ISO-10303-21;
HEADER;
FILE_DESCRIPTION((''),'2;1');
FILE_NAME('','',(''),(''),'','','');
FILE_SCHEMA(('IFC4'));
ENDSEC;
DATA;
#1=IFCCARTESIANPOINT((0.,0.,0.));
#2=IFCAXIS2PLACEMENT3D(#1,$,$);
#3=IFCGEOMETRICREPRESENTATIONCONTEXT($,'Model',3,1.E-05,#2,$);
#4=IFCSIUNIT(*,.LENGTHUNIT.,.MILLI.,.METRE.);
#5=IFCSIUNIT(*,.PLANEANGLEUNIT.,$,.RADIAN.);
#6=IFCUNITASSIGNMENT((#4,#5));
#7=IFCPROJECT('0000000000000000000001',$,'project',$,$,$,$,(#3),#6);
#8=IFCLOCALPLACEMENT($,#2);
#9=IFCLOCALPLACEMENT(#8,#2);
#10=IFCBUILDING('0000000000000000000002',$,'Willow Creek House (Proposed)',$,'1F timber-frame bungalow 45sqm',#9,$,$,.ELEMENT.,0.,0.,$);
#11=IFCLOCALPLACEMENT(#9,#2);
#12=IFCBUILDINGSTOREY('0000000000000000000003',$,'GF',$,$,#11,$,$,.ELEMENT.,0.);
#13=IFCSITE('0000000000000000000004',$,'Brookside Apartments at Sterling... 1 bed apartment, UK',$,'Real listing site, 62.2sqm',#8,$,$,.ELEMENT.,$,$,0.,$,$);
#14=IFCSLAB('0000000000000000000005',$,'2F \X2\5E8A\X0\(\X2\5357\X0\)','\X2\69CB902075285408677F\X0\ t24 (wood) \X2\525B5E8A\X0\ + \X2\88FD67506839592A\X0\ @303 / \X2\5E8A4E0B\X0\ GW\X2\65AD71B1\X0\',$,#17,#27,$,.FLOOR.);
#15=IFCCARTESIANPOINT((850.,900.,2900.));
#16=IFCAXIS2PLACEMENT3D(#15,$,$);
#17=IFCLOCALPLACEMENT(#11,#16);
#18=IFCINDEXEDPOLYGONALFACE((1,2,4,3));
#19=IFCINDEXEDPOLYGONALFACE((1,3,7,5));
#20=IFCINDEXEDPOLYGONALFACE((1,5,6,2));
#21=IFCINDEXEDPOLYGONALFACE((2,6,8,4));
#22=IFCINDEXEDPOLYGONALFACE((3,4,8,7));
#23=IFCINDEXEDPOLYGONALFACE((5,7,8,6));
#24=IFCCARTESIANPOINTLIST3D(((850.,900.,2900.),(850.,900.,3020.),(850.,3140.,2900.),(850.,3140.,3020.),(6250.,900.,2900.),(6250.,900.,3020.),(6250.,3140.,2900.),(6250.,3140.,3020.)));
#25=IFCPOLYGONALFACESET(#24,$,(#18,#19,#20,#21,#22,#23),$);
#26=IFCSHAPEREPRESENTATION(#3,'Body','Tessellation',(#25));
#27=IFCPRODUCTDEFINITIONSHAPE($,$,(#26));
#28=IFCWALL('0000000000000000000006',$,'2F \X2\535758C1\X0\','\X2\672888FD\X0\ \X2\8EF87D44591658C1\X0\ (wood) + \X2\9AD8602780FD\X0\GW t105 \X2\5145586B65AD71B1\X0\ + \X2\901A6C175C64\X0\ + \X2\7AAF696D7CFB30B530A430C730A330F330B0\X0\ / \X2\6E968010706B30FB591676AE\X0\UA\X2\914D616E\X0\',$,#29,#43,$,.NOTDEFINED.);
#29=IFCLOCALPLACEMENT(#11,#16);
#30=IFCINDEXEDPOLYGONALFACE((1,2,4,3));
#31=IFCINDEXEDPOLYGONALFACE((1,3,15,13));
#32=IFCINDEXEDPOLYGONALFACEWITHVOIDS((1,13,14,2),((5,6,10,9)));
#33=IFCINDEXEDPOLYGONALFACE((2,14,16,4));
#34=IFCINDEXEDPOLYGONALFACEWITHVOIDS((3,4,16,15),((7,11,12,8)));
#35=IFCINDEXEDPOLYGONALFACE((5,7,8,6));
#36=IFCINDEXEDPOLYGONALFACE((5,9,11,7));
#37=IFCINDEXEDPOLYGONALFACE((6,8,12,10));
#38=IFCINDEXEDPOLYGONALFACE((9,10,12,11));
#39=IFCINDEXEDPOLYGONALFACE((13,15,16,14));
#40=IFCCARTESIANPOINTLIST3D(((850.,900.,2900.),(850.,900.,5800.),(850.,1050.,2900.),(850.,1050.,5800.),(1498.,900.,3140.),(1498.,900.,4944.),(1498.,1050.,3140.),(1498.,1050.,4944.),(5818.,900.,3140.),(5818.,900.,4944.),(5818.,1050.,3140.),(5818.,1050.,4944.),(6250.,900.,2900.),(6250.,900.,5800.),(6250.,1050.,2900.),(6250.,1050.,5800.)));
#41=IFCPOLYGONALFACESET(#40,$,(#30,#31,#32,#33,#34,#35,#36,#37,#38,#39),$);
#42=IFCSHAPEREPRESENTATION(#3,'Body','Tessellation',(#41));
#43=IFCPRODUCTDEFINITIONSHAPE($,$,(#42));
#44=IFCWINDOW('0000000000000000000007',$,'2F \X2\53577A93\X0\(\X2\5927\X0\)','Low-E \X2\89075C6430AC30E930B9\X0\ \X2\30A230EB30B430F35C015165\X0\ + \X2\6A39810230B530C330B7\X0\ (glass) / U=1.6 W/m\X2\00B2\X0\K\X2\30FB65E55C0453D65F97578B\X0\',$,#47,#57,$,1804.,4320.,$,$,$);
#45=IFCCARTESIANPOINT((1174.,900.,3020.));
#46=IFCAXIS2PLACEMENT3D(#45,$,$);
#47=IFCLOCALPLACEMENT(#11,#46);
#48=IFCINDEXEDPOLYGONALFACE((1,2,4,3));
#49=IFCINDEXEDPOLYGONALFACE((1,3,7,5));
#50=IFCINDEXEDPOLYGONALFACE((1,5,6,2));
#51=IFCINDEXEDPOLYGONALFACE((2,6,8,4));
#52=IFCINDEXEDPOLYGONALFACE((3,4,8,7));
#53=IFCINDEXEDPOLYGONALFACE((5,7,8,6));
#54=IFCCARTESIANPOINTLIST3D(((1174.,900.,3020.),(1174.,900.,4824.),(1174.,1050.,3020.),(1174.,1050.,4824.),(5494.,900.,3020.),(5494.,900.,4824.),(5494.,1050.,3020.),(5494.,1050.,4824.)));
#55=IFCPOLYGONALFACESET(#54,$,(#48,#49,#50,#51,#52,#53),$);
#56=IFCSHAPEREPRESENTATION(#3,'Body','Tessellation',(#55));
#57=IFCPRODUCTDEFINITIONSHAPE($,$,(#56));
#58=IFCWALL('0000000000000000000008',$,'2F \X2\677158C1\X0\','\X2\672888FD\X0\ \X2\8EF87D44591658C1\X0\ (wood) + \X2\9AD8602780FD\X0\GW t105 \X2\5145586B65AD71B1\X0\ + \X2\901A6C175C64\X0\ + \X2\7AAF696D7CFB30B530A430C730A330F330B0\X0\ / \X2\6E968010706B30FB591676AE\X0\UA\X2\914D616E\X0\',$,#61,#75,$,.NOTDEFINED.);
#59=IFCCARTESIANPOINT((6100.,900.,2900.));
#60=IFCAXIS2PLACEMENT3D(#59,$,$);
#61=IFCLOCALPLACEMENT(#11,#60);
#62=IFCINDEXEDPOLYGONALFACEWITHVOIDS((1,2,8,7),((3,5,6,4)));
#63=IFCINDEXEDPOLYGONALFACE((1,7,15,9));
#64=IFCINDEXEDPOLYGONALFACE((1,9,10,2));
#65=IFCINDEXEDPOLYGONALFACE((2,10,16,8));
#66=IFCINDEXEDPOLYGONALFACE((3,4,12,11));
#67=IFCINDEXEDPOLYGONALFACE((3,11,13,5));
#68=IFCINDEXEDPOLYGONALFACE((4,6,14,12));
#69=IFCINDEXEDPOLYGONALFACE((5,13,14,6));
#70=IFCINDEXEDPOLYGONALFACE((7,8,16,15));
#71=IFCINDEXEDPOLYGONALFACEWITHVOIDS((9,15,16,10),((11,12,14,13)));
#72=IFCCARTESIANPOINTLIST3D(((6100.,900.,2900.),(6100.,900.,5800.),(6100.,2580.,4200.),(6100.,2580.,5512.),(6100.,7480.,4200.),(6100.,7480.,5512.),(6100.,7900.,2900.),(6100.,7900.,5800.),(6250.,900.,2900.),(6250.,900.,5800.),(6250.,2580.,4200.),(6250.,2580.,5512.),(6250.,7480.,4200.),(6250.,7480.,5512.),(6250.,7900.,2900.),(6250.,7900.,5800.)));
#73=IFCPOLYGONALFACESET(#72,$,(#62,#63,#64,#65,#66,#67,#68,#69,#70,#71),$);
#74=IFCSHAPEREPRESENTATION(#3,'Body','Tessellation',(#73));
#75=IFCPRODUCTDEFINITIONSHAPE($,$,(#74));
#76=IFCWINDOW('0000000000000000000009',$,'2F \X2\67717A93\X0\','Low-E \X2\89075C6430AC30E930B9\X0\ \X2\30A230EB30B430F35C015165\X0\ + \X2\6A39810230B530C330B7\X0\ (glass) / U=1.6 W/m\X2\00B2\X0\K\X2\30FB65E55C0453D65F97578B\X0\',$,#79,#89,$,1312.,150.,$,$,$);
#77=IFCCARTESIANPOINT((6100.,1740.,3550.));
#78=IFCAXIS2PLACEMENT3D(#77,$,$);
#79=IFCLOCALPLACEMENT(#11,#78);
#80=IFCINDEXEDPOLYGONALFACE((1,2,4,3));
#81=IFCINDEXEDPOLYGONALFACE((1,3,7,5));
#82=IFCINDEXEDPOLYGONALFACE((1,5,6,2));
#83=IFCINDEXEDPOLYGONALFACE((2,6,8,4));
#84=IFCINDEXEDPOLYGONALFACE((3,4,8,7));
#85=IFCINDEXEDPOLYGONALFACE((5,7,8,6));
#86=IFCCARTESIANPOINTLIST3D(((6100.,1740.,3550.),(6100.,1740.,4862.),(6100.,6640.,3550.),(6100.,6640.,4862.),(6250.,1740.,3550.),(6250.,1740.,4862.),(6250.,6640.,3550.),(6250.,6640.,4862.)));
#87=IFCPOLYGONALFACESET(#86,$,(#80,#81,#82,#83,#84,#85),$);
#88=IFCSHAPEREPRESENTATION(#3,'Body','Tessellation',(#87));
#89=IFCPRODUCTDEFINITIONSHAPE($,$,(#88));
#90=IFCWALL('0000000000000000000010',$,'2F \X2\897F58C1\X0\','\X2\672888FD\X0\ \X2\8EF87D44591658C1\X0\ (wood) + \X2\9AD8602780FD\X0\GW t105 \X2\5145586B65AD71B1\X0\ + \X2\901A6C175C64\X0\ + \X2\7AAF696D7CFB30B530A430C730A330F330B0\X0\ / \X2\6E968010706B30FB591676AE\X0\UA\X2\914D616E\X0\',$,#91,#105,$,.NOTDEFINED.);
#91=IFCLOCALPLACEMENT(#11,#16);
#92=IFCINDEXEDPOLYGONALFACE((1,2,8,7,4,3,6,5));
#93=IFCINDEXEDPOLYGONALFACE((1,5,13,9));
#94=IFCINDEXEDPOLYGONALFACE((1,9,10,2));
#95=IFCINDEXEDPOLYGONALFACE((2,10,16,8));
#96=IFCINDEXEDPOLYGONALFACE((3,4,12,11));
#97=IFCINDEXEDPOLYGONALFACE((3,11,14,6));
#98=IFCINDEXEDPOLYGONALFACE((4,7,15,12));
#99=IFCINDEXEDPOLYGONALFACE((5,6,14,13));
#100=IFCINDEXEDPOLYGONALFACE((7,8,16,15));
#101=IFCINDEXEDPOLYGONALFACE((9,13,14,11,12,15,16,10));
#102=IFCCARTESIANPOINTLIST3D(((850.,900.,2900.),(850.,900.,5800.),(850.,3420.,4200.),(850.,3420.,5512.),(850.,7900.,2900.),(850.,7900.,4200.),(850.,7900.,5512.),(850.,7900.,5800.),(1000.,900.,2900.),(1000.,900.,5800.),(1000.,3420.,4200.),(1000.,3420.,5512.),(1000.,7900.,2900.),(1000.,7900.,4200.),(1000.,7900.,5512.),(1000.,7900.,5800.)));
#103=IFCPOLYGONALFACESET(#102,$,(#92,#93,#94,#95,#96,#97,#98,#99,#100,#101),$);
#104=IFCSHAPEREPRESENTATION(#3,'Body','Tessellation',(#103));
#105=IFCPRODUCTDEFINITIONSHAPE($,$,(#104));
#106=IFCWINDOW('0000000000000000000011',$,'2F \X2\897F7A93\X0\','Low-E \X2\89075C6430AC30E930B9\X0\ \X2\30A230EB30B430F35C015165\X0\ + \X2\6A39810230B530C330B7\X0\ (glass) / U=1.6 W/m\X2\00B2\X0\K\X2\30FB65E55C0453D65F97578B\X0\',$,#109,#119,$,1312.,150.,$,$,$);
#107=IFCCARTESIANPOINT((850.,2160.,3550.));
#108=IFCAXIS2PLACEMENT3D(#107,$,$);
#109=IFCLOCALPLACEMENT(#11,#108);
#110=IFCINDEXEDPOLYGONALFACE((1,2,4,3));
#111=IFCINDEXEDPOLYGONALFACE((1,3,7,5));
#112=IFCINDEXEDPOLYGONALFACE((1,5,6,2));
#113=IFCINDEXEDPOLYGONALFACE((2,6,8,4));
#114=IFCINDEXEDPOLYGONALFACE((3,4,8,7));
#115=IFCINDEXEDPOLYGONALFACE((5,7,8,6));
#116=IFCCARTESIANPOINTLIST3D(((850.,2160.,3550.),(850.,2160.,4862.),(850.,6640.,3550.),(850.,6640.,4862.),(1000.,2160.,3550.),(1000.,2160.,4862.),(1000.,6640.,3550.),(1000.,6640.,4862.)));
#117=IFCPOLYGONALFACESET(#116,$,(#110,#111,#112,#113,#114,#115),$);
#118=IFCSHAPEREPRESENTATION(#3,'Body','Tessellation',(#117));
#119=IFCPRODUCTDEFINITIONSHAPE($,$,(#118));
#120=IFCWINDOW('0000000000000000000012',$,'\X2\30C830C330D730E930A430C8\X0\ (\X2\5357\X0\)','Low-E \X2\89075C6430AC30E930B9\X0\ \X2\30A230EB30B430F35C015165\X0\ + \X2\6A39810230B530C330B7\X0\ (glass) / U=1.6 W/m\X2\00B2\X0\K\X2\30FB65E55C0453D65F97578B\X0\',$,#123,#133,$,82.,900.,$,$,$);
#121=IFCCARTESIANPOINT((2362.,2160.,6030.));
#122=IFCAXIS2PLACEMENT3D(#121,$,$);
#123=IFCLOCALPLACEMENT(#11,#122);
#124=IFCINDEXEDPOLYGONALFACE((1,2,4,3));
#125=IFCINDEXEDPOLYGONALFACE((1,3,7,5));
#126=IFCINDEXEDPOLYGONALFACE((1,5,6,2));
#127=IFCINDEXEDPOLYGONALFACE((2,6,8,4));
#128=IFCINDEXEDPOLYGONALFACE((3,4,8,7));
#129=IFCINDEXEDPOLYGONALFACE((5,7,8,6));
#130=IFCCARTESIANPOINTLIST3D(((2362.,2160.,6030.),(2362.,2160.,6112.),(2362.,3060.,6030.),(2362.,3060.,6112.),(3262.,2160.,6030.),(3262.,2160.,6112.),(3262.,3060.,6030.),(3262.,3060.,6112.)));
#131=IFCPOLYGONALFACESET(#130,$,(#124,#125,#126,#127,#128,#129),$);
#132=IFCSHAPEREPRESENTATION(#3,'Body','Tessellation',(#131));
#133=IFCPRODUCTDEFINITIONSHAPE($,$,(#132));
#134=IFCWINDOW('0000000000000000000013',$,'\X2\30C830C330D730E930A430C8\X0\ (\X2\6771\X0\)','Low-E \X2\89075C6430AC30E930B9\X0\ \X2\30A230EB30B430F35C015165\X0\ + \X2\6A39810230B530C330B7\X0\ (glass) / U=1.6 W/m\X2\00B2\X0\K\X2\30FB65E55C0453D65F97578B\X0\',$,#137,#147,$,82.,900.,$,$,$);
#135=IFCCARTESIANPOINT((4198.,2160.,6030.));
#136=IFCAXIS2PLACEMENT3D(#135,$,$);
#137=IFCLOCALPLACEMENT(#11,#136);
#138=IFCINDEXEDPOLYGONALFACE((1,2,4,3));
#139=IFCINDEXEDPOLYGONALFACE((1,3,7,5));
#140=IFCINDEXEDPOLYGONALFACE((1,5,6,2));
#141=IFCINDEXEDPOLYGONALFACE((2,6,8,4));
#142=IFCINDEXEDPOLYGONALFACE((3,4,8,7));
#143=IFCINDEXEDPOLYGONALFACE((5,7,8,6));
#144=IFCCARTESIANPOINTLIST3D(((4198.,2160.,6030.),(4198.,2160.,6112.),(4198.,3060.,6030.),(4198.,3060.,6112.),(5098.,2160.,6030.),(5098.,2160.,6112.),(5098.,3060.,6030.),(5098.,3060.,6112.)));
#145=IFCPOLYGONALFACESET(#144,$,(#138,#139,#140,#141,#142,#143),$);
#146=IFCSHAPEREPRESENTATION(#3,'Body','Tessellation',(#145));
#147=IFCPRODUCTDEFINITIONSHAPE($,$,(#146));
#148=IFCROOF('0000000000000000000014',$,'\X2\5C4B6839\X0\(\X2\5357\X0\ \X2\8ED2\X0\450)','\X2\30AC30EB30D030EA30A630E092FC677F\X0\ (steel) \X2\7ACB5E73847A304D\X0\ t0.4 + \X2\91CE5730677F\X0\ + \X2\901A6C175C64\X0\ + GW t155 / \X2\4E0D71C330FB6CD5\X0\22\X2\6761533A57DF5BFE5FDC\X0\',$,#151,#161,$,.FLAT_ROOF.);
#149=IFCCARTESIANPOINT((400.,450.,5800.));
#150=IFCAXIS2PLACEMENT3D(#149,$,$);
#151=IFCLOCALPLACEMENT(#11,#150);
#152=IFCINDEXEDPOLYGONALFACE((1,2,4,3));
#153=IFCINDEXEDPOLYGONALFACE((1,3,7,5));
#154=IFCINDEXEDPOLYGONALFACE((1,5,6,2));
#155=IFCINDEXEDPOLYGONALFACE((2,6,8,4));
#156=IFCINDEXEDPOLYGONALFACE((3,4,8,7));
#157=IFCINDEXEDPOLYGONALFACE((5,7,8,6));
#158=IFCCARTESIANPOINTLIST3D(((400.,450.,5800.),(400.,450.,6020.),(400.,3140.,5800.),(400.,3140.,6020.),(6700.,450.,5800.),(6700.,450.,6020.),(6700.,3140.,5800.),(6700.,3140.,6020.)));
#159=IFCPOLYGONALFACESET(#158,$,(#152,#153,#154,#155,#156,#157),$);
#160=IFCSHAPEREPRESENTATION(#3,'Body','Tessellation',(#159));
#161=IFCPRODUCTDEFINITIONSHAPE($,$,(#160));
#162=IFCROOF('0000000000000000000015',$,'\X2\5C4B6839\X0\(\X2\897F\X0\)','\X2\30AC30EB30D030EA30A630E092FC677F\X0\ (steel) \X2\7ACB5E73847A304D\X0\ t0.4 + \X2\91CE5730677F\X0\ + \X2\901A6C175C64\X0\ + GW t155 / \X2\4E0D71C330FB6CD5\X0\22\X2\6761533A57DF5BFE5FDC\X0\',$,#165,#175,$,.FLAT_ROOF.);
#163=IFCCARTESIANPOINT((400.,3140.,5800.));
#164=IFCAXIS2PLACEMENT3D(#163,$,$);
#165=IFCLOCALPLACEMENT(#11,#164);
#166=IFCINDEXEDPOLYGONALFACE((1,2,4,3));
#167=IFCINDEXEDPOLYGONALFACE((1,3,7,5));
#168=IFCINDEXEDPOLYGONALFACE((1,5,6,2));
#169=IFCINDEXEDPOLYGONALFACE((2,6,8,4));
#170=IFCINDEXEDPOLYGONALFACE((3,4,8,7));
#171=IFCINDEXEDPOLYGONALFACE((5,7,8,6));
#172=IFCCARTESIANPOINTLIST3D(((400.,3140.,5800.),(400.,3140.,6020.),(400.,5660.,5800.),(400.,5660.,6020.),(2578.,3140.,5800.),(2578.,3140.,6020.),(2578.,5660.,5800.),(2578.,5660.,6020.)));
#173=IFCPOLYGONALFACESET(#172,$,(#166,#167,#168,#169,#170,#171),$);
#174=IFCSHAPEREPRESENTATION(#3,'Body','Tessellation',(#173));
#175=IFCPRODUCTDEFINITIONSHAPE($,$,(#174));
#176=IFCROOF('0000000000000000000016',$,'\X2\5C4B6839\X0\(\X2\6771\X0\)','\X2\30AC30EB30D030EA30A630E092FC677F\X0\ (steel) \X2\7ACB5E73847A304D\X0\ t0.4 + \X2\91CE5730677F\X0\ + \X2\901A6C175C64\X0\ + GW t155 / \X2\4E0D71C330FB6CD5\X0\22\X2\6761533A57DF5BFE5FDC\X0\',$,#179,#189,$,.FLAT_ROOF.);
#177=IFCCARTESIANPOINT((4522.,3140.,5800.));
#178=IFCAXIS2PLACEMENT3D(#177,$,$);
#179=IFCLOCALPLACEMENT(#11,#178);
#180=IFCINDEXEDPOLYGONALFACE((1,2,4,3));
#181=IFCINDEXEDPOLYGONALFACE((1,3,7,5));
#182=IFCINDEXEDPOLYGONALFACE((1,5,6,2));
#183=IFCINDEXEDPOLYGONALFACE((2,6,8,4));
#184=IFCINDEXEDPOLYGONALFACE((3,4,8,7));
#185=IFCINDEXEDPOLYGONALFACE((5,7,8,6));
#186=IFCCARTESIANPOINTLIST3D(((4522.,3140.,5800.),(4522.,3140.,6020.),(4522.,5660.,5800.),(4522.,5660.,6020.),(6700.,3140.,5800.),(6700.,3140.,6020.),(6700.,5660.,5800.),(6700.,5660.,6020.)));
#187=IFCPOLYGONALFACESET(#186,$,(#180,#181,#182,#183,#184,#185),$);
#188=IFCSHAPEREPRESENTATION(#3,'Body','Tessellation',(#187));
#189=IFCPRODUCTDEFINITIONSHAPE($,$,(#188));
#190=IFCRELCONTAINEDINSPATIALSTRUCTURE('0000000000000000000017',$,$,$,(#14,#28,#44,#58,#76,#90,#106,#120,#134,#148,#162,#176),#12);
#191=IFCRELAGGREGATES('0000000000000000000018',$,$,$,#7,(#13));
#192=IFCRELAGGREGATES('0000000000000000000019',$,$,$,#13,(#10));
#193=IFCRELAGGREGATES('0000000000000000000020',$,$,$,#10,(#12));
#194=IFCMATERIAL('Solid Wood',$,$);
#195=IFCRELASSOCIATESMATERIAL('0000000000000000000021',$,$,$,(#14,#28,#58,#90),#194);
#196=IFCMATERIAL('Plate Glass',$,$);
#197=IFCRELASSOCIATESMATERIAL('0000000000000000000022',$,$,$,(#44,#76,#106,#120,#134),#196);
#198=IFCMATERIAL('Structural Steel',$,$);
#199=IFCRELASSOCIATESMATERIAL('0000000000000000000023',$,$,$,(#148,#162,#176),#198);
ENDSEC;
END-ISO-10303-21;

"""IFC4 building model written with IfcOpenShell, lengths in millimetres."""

from ifc_helpers import new_model, si_unit, frame, frame_2d, origin, place, context, project, spatial, rectangle, extrude, material, element, fill, save


model = new_model("IFC4")

# Units and contexts
model_context = context("Model", 3, precision=1e-05, world=origin())
ifc_project = project(units=[si_unit("LENGTHUNIT", "METRE", prefix="MILLI"), si_unit("PLANEANGLEUNIT", "RADIAN")], contexts=[model_context])

# Site, building, storey
site_placement = place(None, origin())
site = spatial("IfcSite", under=ifc_project, at=site_placement, Name="Brookside Apartments at Sterling... 1 bed apartment, UK", ObjectType="Real listing site, 62.2sqm", CompositionType="ELEMENT", RefElevation=0.0)
building_placement = place(site_placement, origin())
building = spatial("IfcBuilding", under=site, at=building_placement, Name="Willow Creek House (Proposed)", ObjectType="1F timber-frame bungalow 45sqm", CompositionType="ELEMENT", ElevationOfRefHeight=0.0, ElevationOfTerrain=0.0)
storey_placement = place(building_placement, origin())
storey = spatial("IfcBuildingStorey", under=building, at=storey_placement, Name="GF", CompositionType="ELEMENT", Elevation=0.0)

# Slab
ifc_material_1 = material(Name="Solid Wood")
slab_placement = place(storey_placement, frame((850.0, 900.0, 2900.0)))
element("IfcSlab", 1, at=slab_placement, inside=storey, material=ifc_material_1, Name="2F 床(南)", Description="構造用合板 t24 (wood) 剛床 + 製材根太 @303 / 床下 GW断熱", PredefinedType="FLOOR", context=model_context, shape_type="SweptSolid", body=[
    extrude(rectangle(XDim=5400.0, YDim=2240.0, at=frame_2d((2700.0, 1120.0))), frame((850.0, 900.0, 2900.0)), (0.0, 0.0, 1.0), 120.0),
])

# Walls, openings, windows
wall_1_placement = place(storey_placement, frame((850.0, 900.0, 2900.0)))
wall_1 = element("IfcWall", 2, at=wall_1_placement, inside=storey, material=ifc_material_1, Name="2F 南壁", Description="木製 軸組外壁 (wood) + 高性能GW t105 充填断熱 + 通気層 + 窯業系サイディング / 準耐火・外皮UA配慮", PredefinedType="NOTDEFINED", context=model_context, shape_type="SweptSolid", body=[
    extrude(rectangle(XDim=5400.0, YDim=150.0, at=frame_2d((2700.0, 75.0))), frame((850.0, 900.0, 2900.0)), (0.0, 0.0, 1.0), 2900.0),
])
opening_1_placement = place(storey_placement, frame((1174.0, 900.0, 3020.0)))
opening_1 = element("IfcOpeningElement", 3, at=opening_1_placement, cuts=wall_1, PredefinedType="NOTDEFINED", context=model_context, shape_type="SweptSolid", body=[
    extrude(rectangle(XDim=4320.0, YDim=150.0, at=frame_2d((2160.0, 75.0))), frame((1174.0, 900.0, 3020.0)), (0.0, 0.0, 1.0), 1804.0),
])
ifc_material_2 = material(Name="Plate Glass")
window_1_placement = place(storey_placement, frame((1174.0, 900.0, 3020.0)))
window_1 = element("IfcWindow", 4, at=window_1_placement, inside=storey, material=ifc_material_2, Name="2F 南窓(大)", Description="Low-E 複層ガラス アルゴン封入 + 樹脂サッシ (glass) / U=1.6 W/m²K・日射取得型", OverallHeight=1804.0, OverallWidth=4320.0, context=model_context, shape_type="SweptSolid", body=[
    extrude(rectangle(XDim=4320.0, YDim=150.0, at=frame_2d((2160.0, 75.0))), frame((1174.0, 900.0, 3020.0)), (0.0, 0.0, 1.0), 1804.0),
])
fill(opening_1, window_1)
wall_2_placement = place(storey_placement, frame((6100.0, 900.0, 2900.0)))
wall_2 = element("IfcWall", 5, at=wall_2_placement, inside=storey, material=ifc_material_1, Name="2F 東壁", Description="木製 軸組外壁 (wood) + 高性能GW t105 充填断熱 + 通気層 + 窯業系サイディング / 準耐火・外皮UA配慮", PredefinedType="NOTDEFINED", context=model_context, shape_type="SweptSolid", body=[
    extrude(rectangle(XDim=150.0, YDim=7000.0, at=frame_2d((75.0, 3500.0))), frame((6100.0, 900.0, 2900.0)), (0.0, 0.0, 1.0), 2900.0),
])
opening_2_placement = place(storey_placement, frame((6100.0, 1740.0, 3550.0)))
opening_2 = element("IfcOpeningElement", 6, at=opening_2_placement, cuts=wall_2, PredefinedType="NOTDEFINED", context=model_context, shape_type="SweptSolid", body=[
    extrude(rectangle(XDim=150.0, YDim=4900.0, at=frame_2d((75.0, 2450.0))), frame((6100.0, 1740.0, 3550.0)), (0.0, 0.0, 1.0), 1312.0),
])
window_2_placement = place(storey_placement, frame((6100.0, 1740.0, 3550.0)))
window_2 = element("IfcWindow", 7, at=window_2_placement, inside=storey, material=ifc_material_2, Name="2F 東窓", Description="Low-E 複層ガラス アルゴン封入 + 樹脂サッシ (glass) / U=1.6 W/m²K・日射取得型", OverallHeight=1312.0, OverallWidth=150.0, context=model_context, shape_type="SweptSolid", body=[
    extrude(rectangle(XDim=150.0, YDim=4900.0, at=frame_2d((75.0, 2450.0))), frame((6100.0, 1740.0, 3550.0)), (0.0, 0.0, 1.0), 1312.0),
])
fill(opening_2, window_2)
wall_3_placement = place(storey_placement, frame((850.0, 900.0, 2900.0)))
wall_3 = element("IfcWall", 8, at=wall_3_placement, inside=storey, material=ifc_material_1, Name="2F 西壁", Description="木製 軸組外壁 (wood) + 高性能GW t105 充填断熱 + 通気層 + 窯業系サイディング / 準耐火・外皮UA配慮", PredefinedType="NOTDEFINED", context=model_context, shape_type="SweptSolid", body=[
    extrude(rectangle(XDim=150.0, YDim=7000.0, at=frame_2d((75.0, 3500.0))), frame((850.0, 900.0, 2900.0)), (0.0, 0.0, 1.0), 2900.0),
])
opening_3_placement = place(storey_placement, frame((850.0, 2160.0, 3550.0)))
opening_3 = element("IfcOpeningElement", 9, at=opening_3_placement, cuts=wall_3, PredefinedType="NOTDEFINED", context=model_context, shape_type="SweptSolid", body=[
    extrude(rectangle(XDim=150.0, YDim=4480.0, at=frame_2d((75.0, 2240.0))), frame((850.0, 2160.0, 3550.0)), (0.0, 0.0, 1.0), 1312.0),
])
window_3_placement = place(storey_placement, frame((850.0, 2160.0, 3550.0)))
window_3 = element("IfcWindow", 10, at=window_3_placement, inside=storey, material=ifc_material_2, Name="2F 西窓", Description="Low-E 複層ガラス アルゴン封入 + 樹脂サッシ (glass) / U=1.6 W/m²K・日射取得型", OverallHeight=1312.0, OverallWidth=150.0, context=model_context, shape_type="SweptSolid", body=[
    extrude(rectangle(XDim=150.0, YDim=4480.0, at=frame_2d((75.0, 2240.0))), frame((850.0, 2160.0, 3550.0)), (0.0, 0.0, 1.0), 1312.0),
])
fill(opening_3, window_3)

# Windows
window_4_placement = place(storey_placement, frame((2362.0, 2160.0, 6030.0)))
element("IfcWindow", 11, at=window_4_placement, inside=storey, material=ifc_material_2, Name="トップライト (南)", Description="Low-E 複層ガラス アルゴン封入 + 樹脂サッシ (glass) / U=1.6 W/m²K・日射取得型", OverallHeight=82.0, OverallWidth=900.0, context=model_context, shape_type="SweptSolid", body=[
    extrude(rectangle(XDim=900.0, YDim=900.0, at=frame_2d((450.0, 450.0))), frame((2362.0, 2160.0, 6030.0)), (0.0, 0.0, 1.0), 82.0),
])
window_5_placement = place(storey_placement, frame((4198.0, 2160.0, 6030.0)))
element("IfcWindow", 12, at=window_5_placement, inside=storey, material=ifc_material_2, Name="トップライト (東)", Description="Low-E 複層ガラス アルゴン封入 + 樹脂サッシ (glass) / U=1.6 W/m²K・日射取得型", OverallHeight=82.0, OverallWidth=900.0, context=model_context, shape_type="SweptSolid", body=[
    extrude(rectangle(XDim=900.0, YDim=900.0, at=frame_2d((450.0, 450.0))), frame((4198.0, 2160.0, 6030.0)), (0.0, 0.0, 1.0), 82.0),
])

# Roofs
ifc_material_3 = material(Name="Structural Steel")
roof_1_placement = place(storey_placement, frame((400.0, 450.0, 5800.0)))
element("IfcRoof", 13, at=roof_1_placement, inside=storey, material=ifc_material_3, Name="屋根(南 軒450)", Description="ガルバリウム鋼板 (steel) 立平葺き t0.4 + 野地板 + 通気層 + GW t155 / 不燃・法22条区域対応", PredefinedType="FLAT_ROOF", context=model_context, shape_type="SweptSolid", body=[
    extrude(rectangle(XDim=6300.0, YDim=2690.0, at=frame_2d((3150.0, 1345.0))), frame((400.0, 450.0, 5800.0)), (0.0, 0.0, 1.0), 220.0),
])
roof_2_placement = place(storey_placement, frame((400.0, 3140.0, 5800.0)))
element("IfcRoof", 14, at=roof_2_placement, inside=storey, material=ifc_material_3, Name="屋根(西)", Description="ガルバリウム鋼板 (steel) 立平葺き t0.4 + 野地板 + 通気層 + GW t155 / 不燃・法22条区域対応", PredefinedType="FLAT_ROOF", context=model_context, shape_type="SweptSolid", body=[
    extrude(rectangle(XDim=2178.0, YDim=2520.0, at=frame_2d((1089.0, 1260.0))), frame((400.0, 3140.0, 5800.0)), (0.0, 0.0, 1.0), 220.0),
])
roof_3_placement = place(storey_placement, frame((4522.0, 3140.0, 5800.0)))
element("IfcRoof", 15, at=roof_3_placement, inside=storey, material=ifc_material_3, Name="屋根(東)", Description="ガルバリウム鋼板 (steel) 立平葺き t0.4 + 野地板 + 通気層 + GW t155 / 不燃・法22条区域対応", PredefinedType="FLAT_ROOF", context=model_context, shape_type="SweptSolid", body=[
    extrude(rectangle(XDim=2178.0, YDim=2520.0, at=frame_2d((1089.0, 1260.0))), frame((4522.0, 3140.0, 5800.0)), (0.0, 0.0, 1.0), 220.0),
])

save(model, "model.ifc")
